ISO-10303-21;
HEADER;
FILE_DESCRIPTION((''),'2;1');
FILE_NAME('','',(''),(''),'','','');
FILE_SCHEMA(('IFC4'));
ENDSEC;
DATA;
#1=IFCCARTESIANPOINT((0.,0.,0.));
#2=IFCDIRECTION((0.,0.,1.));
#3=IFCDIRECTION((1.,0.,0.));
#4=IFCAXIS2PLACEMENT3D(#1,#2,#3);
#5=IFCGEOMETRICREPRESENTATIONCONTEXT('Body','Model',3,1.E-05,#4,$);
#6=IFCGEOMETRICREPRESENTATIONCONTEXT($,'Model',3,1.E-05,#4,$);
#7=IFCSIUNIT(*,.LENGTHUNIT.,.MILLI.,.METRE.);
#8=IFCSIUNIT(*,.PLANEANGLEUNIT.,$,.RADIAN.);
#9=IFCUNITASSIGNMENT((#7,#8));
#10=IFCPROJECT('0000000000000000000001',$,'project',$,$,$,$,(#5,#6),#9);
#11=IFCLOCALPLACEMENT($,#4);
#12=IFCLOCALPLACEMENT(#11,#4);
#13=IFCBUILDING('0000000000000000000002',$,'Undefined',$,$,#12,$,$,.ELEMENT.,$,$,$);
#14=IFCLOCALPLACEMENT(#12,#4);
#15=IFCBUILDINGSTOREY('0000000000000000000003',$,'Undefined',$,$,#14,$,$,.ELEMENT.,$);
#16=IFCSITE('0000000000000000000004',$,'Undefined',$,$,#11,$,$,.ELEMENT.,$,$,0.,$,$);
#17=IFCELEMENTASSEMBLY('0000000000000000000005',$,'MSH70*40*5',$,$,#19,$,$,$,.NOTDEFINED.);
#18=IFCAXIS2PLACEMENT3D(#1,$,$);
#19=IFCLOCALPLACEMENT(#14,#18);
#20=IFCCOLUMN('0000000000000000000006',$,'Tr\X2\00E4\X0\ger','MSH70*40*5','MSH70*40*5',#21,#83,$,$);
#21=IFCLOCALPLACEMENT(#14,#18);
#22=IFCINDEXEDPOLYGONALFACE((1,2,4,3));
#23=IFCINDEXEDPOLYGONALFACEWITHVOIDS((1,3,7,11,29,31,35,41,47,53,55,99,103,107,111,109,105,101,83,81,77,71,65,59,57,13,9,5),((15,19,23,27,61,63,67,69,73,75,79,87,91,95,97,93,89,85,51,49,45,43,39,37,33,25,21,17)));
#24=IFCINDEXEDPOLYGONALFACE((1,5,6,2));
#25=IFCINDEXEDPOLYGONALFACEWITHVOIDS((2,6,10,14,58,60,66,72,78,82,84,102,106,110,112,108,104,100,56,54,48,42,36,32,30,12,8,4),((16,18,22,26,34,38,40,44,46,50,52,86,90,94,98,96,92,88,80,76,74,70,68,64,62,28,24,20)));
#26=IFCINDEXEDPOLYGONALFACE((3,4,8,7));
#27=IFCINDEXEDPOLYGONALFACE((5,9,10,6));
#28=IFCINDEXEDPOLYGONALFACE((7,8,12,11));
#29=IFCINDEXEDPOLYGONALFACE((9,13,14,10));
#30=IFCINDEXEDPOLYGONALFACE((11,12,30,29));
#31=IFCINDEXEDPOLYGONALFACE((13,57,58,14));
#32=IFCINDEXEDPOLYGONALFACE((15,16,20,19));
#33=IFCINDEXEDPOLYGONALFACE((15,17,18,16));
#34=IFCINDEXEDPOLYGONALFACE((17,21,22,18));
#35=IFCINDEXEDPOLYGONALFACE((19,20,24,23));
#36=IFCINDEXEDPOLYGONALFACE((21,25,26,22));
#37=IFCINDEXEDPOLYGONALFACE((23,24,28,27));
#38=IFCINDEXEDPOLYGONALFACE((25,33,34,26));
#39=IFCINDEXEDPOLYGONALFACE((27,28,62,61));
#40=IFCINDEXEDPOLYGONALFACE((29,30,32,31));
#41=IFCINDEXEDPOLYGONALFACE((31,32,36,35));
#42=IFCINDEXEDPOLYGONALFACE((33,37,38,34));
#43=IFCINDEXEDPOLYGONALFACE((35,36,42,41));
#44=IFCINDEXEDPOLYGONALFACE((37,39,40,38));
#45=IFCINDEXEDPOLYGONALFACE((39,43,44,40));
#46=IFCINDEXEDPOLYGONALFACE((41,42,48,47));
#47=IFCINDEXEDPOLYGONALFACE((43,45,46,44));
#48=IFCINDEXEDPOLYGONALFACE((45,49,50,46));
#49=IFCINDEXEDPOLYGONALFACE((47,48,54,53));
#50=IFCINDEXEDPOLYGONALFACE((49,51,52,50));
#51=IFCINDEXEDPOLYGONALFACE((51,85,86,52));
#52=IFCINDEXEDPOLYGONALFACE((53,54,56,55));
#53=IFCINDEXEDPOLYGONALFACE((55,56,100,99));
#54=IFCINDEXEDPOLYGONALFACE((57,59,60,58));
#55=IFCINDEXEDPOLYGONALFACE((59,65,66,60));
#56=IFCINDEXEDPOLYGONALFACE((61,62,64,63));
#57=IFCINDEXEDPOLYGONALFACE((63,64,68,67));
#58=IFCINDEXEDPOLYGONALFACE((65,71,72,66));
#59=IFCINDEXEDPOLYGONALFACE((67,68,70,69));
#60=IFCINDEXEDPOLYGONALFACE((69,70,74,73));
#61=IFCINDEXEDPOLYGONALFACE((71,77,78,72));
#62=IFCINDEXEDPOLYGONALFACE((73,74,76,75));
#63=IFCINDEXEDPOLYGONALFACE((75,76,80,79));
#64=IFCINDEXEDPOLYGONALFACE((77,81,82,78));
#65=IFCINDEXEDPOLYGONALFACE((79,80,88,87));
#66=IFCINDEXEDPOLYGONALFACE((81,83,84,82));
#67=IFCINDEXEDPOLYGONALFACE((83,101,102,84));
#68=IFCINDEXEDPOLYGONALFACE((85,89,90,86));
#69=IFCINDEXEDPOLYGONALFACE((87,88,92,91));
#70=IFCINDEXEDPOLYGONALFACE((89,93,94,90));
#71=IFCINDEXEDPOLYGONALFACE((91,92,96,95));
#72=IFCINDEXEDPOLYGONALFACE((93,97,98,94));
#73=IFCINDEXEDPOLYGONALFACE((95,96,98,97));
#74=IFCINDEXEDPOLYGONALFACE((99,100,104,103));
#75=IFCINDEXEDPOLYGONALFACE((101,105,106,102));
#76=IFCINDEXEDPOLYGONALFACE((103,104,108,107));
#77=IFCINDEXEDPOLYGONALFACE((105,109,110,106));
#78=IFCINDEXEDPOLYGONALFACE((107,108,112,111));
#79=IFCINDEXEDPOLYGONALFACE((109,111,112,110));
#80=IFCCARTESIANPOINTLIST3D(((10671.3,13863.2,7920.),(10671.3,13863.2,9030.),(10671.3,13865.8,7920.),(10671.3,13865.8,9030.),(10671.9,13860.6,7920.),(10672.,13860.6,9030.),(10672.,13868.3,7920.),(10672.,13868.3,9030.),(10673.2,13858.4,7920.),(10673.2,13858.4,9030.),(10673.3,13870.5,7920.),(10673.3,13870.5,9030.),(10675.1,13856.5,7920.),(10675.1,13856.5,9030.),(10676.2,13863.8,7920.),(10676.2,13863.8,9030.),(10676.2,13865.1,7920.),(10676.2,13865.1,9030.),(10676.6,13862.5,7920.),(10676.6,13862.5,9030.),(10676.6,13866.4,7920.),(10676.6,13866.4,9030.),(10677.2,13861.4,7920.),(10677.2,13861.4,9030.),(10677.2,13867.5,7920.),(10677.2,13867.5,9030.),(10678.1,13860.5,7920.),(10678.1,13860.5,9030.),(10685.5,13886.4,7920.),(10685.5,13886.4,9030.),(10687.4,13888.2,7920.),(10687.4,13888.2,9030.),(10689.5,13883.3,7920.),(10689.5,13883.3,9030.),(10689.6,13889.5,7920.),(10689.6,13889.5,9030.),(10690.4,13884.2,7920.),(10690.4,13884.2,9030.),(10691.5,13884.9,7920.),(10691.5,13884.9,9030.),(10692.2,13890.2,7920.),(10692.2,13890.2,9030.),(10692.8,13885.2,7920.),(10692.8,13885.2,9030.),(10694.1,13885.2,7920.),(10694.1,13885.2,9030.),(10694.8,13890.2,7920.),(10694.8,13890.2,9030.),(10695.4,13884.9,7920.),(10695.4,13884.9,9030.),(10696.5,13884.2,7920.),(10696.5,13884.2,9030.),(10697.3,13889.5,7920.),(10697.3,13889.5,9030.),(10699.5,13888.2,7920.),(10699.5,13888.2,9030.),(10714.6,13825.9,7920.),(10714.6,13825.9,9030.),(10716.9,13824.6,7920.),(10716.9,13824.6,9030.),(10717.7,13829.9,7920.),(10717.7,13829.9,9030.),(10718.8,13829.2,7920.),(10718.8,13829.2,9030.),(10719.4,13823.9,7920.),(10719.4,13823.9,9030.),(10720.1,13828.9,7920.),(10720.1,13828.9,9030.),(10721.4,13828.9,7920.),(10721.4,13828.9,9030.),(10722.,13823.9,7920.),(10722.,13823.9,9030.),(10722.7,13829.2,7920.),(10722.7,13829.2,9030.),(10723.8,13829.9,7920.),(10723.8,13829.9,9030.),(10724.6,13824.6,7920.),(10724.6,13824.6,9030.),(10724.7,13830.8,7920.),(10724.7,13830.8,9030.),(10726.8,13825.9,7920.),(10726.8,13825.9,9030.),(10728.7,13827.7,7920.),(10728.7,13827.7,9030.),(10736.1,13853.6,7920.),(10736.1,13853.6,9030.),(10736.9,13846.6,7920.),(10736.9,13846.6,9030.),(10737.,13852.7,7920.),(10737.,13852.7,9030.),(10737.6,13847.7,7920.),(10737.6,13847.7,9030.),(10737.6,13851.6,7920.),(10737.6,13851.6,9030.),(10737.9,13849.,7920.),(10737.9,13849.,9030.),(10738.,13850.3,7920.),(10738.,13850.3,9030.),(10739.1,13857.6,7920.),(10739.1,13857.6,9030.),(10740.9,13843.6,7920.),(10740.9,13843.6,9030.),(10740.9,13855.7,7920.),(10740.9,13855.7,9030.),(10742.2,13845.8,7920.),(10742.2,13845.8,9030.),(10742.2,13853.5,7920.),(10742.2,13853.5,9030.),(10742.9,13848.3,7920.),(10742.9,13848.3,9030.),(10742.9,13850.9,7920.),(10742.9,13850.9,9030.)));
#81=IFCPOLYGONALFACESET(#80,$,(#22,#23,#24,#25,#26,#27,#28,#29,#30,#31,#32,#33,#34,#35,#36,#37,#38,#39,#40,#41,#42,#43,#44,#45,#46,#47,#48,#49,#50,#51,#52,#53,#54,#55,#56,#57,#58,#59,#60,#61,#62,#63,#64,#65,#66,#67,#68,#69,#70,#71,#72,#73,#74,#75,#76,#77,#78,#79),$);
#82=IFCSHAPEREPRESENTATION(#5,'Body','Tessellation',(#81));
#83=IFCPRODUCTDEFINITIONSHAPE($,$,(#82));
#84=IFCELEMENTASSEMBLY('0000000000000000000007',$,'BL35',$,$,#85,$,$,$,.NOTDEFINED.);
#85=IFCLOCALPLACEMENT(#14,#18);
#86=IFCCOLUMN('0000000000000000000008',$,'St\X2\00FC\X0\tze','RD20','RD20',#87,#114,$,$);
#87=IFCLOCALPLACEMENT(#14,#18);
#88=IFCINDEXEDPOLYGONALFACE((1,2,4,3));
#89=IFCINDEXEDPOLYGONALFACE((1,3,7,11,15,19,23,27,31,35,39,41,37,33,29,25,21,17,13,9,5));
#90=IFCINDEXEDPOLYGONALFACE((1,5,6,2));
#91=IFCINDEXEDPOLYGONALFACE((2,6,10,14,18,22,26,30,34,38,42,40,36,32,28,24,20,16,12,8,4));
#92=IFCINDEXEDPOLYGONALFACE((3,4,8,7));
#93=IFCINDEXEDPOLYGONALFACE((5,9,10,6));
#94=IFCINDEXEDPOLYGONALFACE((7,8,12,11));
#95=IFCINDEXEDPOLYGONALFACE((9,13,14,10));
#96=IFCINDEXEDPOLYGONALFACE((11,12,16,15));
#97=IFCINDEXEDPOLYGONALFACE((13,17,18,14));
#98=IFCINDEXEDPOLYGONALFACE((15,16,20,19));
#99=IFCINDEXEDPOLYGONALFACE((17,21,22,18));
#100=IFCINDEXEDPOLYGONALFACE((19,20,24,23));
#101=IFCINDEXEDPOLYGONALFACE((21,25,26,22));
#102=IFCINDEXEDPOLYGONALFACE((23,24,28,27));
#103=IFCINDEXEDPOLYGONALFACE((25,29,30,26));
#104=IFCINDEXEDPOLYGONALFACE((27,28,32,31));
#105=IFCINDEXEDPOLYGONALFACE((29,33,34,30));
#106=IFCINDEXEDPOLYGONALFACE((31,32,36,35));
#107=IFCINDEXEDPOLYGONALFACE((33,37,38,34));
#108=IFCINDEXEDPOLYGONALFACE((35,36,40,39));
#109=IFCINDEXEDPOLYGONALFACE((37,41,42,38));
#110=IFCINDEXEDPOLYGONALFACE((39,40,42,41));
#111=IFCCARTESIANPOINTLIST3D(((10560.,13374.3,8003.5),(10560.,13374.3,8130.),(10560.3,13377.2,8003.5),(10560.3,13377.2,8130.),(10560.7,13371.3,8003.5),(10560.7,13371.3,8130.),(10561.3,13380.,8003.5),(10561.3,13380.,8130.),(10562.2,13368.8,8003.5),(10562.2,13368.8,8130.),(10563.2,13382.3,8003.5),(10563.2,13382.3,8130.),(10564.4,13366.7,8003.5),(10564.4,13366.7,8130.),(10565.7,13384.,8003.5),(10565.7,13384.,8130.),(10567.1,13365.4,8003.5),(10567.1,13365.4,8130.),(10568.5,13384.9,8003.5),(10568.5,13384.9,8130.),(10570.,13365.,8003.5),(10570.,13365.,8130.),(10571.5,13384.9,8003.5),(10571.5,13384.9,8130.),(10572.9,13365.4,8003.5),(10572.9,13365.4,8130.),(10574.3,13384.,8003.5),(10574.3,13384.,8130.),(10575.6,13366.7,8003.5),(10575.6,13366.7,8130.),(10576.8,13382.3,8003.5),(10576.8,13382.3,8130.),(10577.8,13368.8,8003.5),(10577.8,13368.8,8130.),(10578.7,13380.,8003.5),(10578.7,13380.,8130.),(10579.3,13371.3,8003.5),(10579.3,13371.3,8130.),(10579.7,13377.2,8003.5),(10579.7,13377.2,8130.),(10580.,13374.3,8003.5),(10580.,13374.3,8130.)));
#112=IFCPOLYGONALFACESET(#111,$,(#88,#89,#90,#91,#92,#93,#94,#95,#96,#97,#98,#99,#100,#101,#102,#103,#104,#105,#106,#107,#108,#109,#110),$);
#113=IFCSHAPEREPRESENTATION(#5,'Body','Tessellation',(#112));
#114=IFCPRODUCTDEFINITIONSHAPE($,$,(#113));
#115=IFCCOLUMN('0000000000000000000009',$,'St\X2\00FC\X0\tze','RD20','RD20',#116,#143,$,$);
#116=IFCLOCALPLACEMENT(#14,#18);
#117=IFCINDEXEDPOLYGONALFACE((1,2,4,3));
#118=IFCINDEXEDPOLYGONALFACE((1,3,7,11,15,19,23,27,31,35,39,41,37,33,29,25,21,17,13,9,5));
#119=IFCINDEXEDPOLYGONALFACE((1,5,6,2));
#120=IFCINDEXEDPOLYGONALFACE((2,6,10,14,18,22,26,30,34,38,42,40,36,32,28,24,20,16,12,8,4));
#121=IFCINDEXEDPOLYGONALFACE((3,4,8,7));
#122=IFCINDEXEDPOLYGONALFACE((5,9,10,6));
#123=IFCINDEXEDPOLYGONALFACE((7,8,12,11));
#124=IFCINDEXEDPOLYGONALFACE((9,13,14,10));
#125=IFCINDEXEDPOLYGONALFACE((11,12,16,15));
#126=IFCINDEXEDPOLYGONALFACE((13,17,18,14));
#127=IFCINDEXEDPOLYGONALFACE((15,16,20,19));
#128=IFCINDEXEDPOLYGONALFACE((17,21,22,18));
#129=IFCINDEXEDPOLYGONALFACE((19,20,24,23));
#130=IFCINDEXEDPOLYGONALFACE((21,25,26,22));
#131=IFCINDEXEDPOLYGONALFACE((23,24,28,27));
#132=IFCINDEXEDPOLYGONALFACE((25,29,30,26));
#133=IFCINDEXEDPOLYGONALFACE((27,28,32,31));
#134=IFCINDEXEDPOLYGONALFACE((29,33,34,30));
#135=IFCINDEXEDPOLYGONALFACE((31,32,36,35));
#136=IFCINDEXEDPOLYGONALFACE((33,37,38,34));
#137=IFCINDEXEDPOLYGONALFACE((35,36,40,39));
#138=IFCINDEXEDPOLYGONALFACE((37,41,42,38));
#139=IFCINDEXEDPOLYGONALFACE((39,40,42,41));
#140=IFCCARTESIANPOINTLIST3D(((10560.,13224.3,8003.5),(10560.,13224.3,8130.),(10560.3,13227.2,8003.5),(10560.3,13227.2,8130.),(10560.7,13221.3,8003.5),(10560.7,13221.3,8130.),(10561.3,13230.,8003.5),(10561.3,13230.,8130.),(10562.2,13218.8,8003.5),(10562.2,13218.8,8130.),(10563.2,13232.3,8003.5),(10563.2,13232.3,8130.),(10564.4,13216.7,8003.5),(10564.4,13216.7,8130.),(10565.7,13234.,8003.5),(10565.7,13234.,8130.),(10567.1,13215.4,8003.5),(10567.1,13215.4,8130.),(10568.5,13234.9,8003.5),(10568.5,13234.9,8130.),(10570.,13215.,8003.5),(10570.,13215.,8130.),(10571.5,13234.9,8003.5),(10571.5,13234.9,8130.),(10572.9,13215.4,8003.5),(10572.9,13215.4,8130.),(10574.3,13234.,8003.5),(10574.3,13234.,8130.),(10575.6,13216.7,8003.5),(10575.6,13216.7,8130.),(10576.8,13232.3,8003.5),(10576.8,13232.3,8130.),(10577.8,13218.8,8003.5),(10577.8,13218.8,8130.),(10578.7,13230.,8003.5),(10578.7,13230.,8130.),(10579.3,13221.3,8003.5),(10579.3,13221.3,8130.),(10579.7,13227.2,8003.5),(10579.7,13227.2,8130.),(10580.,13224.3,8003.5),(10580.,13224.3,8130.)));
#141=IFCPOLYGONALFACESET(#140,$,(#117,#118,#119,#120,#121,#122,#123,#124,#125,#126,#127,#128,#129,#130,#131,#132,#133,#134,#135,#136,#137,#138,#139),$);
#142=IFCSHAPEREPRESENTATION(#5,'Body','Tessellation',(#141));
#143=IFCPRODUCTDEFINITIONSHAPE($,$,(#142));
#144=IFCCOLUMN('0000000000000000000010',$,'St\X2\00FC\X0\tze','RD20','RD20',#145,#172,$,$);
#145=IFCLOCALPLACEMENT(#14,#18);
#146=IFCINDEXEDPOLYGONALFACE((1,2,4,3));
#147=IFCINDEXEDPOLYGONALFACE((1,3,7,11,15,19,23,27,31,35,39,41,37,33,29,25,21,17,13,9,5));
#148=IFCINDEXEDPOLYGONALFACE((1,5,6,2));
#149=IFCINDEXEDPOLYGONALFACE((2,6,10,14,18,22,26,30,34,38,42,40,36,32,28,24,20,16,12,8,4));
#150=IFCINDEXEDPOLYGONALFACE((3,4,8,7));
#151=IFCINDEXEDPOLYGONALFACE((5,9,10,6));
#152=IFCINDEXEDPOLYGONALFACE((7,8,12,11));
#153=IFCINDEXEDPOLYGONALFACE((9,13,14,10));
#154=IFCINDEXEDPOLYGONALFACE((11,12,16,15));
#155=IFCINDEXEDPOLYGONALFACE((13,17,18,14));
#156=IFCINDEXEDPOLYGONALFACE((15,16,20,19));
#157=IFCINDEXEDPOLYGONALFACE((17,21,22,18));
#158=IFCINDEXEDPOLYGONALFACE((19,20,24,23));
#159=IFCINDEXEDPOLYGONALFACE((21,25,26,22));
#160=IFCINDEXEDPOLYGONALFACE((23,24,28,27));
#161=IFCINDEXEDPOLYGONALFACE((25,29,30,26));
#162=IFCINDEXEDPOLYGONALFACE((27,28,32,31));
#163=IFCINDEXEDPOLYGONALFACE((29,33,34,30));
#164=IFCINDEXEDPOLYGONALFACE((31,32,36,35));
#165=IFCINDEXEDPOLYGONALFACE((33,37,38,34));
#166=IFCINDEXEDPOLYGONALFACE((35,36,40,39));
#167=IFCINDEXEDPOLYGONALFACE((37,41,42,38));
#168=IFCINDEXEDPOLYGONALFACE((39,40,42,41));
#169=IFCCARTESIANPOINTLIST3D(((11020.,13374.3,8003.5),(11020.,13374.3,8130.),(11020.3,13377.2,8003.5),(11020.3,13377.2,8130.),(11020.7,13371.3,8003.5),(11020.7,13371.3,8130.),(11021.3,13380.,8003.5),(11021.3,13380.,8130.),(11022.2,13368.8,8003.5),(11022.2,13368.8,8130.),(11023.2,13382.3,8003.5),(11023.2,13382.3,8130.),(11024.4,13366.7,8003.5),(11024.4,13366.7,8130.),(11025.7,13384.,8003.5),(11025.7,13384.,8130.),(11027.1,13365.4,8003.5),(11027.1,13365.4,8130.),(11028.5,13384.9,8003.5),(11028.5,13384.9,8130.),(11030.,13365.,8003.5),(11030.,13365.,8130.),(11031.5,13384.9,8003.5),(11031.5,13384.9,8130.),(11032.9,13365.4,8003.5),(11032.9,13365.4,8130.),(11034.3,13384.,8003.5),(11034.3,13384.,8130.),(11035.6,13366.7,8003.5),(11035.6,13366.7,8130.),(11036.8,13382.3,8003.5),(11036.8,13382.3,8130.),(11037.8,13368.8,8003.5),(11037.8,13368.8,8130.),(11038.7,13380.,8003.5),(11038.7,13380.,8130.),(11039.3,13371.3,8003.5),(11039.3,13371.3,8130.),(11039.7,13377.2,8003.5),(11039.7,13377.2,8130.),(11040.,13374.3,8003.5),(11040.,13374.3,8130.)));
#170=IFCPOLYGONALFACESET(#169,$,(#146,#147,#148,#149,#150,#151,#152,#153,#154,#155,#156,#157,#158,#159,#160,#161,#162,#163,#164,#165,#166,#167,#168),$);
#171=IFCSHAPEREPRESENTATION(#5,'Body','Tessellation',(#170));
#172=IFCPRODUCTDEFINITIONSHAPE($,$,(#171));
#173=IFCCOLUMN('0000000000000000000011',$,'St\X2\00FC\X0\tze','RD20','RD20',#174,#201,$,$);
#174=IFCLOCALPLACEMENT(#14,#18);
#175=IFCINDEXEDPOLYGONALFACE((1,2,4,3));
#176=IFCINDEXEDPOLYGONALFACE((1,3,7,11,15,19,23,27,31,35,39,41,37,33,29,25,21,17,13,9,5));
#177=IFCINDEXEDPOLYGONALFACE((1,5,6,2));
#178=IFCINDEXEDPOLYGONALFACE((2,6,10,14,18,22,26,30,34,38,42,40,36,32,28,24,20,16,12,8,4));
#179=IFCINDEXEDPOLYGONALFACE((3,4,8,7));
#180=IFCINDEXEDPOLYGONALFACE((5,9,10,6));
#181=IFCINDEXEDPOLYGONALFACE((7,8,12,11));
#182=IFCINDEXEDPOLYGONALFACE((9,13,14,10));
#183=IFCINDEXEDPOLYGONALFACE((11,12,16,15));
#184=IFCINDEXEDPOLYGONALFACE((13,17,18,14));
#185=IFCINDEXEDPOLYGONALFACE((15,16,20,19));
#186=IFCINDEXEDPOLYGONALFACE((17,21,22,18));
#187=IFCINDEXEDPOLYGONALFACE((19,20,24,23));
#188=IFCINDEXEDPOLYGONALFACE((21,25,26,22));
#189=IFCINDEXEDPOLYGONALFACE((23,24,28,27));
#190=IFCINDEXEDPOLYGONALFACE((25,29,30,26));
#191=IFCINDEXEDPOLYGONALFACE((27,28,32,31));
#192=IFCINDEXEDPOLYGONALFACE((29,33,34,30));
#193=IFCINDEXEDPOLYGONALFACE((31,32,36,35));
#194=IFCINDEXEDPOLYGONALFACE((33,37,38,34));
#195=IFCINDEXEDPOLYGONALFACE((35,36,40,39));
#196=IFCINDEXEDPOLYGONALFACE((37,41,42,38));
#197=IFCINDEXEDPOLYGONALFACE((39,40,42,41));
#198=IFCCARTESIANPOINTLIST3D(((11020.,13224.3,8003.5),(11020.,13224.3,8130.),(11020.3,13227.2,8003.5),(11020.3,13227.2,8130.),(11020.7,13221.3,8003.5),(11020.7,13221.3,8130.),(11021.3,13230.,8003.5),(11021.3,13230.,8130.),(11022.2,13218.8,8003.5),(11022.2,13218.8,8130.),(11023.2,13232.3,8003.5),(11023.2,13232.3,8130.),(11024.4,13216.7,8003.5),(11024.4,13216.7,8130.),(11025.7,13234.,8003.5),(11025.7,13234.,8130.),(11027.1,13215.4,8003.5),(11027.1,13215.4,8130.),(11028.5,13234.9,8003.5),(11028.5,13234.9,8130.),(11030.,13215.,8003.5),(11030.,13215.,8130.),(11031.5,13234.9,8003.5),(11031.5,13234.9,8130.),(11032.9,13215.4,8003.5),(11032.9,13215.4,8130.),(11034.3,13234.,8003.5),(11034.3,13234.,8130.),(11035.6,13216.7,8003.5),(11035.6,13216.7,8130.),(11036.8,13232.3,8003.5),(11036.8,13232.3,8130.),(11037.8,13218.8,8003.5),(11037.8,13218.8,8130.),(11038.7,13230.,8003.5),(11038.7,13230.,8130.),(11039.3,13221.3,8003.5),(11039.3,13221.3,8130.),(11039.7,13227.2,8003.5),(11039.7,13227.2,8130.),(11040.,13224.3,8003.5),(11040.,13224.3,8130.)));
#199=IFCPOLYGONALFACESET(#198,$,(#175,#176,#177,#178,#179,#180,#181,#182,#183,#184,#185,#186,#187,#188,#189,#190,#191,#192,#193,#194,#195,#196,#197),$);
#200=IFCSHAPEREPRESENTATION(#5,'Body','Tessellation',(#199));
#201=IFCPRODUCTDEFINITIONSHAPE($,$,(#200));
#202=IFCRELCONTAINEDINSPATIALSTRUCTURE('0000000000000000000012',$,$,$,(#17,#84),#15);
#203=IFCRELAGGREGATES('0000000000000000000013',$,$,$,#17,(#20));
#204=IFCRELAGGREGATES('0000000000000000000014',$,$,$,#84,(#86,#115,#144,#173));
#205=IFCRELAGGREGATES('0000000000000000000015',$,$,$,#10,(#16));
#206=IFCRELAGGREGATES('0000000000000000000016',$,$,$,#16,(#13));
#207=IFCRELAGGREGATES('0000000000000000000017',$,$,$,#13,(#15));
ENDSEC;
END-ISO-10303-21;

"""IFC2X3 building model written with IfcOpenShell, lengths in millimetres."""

from ifc_helpers import new_model, si_unit, frame, origin_with_axes, origin_2d_with_axis, place, context, project, spatial, hollow_rectangle, circle, extrude, element, aggregate, save


model = new_model("IFC2X3")

# Units and contexts
model_context_1 = context("Model", 3, precision=1e-05, world=origin_with_axes(), identifier="Body")
model_context_2 = context("Model", 3, precision=1e-05, world=origin_with_axes())
ifc_project = project(units=[si_unit("LENGTHUNIT", "METRE", prefix="MILLI"), si_unit("PLANEANGLEUNIT", "RADIAN")], contexts=[model_context_1, model_context_2])

# Site, building, storey
site_placement = place(None, origin_with_axes())
site = spatial("IfcSite", under=ifc_project, at=site_placement, Name="Undefined", CompositionType="ELEMENT", RefElevation=0.0)
building_placement = place(site_placement, origin_with_axes())
building = spatial("IfcBuilding", under=site, at=building_placement, Name="Undefined", CompositionType="ELEMENT")
storey_placement = place(building_placement, origin_with_axes())
storey = spatial("IfcBuildingStorey", under=building, at=storey_placement, Name="Undefined", CompositionType="ELEMENT")

# Element assembly
assembly_1 = element("IfcElementAssembly", 1, inside=storey, Name="MSH70*40*5", PredefinedType="NOTDEFINED")

# Column
column_1_placement = place(storey_placement, frame((10707.1, 13857.0, 7920.0), z_axis=(0.0, 0.0, 1.0), x_axis=(1.0, 0.0, 0.0)))
column_1 = element("IfcColumn", 2, at=column_1_placement, Name="Träger", Description="MSH70*40*5", ObjectType="MSH70*40*5", context=model_context_1, shape_type="SweptSolid", body=[
    extrude(hollow_rectangle(XDim=40.0, YDim=70.0, WallThickness=5.0, InnerFilletRadius=5.0, OuterFilletRadius=10.0, at=origin_2d_with_axis()), frame((0.0, 0.0, 1110.0), z_axis=(0.0, 0.0, -1.0), x_axis=(0.611527, 0.791224, 0.000005)), (0.0, 0.0, 1.0), 1110.0),
])
aggregate(assembly_1, [column_1])

# Element assembly, columns
assembly_2 = element("IfcElementAssembly", 3, inside=storey, Name="BL35", PredefinedType="NOTDEFINED")
column_2_placement = place(storey_placement, frame((10570.0, 13375.0, 8003.5), z_axis=(0.0, 0.0, 1.0), x_axis=(1.0, 0.0, 0.0)))
column_2 = element("IfcColumn", 4, at=column_2_placement, Name="Stütze", Description="RD20", ObjectType="RD20", context=model_context_1, shape_type="SweptSolid", body=[
    extrude(circle(Radius=10.0, at=origin_2d_with_axis()), frame((0.0, 0.0, 126.5), z_axis=(0.0, 0.0, -1.0), x_axis=(0.0, -1.0, 0.0)), (0.0, 0.0, 1.0), 126.5),
])
column_3_placement = place(storey_placement, frame((10570.0, 13225.0, 8003.5), z_axis=(0.0, 0.0, 1.0), x_axis=(1.0, 0.0, 0.0)))
column_3 = element("IfcColumn", 5, at=column_3_placement, Name="Stütze", Description="RD20", ObjectType="RD20", context=model_context_1, shape_type="SweptSolid", body=[
    extrude(circle(Radius=10.0, at=origin_2d_with_axis()), frame((0.0, 0.0, 126.5), z_axis=(0.0, 0.0, -1.0), x_axis=(0.0, -1.0, 0.0)), (0.0, 0.0, 1.0), 126.5),
])
column_4_placement = place(storey_placement, frame((11030.0, 13375.0, 8003.5), z_axis=(0.0, 0.0, 1.0), x_axis=(1.0, 0.0, 0.0)))
column_4 = element("IfcColumn", 6, at=column_4_placement, Name="Stütze", Description="RD20", ObjectType="RD20", context=model_context_1, shape_type="SweptSolid", body=[
    extrude(circle(Radius=10.0, at=origin_2d_with_axis()), frame((0.0, 0.0, 126.5), z_axis=(0.0, 0.0, -1.0), x_axis=(0.0, -1.0, 0.0)), (0.0, 0.0, 1.0), 126.5),
])
column_5_placement = place(storey_placement, frame((11030.0, 13225.0, 8003.5), z_axis=(0.0, 0.0, 1.0), x_axis=(1.0, 0.0, 0.0)))
column_5 = element("IfcColumn", 7, at=column_5_placement, Name="Stütze", Description="RD20", ObjectType="RD20", context=model_context_1, shape_type="SweptSolid", body=[
    extrude(circle(Radius=10.0, at=origin_2d_with_axis()), frame((0.0, 0.0, 126.5), z_axis=(0.0, 0.0, -1.0), x_axis=(0.0, -1.0, 0.0)), (0.0, 0.0, 1.0), 126.5),
])
aggregate(assembly_2, [column_2, column_3, column_4, column_5])

save(model, "model.ifc")
